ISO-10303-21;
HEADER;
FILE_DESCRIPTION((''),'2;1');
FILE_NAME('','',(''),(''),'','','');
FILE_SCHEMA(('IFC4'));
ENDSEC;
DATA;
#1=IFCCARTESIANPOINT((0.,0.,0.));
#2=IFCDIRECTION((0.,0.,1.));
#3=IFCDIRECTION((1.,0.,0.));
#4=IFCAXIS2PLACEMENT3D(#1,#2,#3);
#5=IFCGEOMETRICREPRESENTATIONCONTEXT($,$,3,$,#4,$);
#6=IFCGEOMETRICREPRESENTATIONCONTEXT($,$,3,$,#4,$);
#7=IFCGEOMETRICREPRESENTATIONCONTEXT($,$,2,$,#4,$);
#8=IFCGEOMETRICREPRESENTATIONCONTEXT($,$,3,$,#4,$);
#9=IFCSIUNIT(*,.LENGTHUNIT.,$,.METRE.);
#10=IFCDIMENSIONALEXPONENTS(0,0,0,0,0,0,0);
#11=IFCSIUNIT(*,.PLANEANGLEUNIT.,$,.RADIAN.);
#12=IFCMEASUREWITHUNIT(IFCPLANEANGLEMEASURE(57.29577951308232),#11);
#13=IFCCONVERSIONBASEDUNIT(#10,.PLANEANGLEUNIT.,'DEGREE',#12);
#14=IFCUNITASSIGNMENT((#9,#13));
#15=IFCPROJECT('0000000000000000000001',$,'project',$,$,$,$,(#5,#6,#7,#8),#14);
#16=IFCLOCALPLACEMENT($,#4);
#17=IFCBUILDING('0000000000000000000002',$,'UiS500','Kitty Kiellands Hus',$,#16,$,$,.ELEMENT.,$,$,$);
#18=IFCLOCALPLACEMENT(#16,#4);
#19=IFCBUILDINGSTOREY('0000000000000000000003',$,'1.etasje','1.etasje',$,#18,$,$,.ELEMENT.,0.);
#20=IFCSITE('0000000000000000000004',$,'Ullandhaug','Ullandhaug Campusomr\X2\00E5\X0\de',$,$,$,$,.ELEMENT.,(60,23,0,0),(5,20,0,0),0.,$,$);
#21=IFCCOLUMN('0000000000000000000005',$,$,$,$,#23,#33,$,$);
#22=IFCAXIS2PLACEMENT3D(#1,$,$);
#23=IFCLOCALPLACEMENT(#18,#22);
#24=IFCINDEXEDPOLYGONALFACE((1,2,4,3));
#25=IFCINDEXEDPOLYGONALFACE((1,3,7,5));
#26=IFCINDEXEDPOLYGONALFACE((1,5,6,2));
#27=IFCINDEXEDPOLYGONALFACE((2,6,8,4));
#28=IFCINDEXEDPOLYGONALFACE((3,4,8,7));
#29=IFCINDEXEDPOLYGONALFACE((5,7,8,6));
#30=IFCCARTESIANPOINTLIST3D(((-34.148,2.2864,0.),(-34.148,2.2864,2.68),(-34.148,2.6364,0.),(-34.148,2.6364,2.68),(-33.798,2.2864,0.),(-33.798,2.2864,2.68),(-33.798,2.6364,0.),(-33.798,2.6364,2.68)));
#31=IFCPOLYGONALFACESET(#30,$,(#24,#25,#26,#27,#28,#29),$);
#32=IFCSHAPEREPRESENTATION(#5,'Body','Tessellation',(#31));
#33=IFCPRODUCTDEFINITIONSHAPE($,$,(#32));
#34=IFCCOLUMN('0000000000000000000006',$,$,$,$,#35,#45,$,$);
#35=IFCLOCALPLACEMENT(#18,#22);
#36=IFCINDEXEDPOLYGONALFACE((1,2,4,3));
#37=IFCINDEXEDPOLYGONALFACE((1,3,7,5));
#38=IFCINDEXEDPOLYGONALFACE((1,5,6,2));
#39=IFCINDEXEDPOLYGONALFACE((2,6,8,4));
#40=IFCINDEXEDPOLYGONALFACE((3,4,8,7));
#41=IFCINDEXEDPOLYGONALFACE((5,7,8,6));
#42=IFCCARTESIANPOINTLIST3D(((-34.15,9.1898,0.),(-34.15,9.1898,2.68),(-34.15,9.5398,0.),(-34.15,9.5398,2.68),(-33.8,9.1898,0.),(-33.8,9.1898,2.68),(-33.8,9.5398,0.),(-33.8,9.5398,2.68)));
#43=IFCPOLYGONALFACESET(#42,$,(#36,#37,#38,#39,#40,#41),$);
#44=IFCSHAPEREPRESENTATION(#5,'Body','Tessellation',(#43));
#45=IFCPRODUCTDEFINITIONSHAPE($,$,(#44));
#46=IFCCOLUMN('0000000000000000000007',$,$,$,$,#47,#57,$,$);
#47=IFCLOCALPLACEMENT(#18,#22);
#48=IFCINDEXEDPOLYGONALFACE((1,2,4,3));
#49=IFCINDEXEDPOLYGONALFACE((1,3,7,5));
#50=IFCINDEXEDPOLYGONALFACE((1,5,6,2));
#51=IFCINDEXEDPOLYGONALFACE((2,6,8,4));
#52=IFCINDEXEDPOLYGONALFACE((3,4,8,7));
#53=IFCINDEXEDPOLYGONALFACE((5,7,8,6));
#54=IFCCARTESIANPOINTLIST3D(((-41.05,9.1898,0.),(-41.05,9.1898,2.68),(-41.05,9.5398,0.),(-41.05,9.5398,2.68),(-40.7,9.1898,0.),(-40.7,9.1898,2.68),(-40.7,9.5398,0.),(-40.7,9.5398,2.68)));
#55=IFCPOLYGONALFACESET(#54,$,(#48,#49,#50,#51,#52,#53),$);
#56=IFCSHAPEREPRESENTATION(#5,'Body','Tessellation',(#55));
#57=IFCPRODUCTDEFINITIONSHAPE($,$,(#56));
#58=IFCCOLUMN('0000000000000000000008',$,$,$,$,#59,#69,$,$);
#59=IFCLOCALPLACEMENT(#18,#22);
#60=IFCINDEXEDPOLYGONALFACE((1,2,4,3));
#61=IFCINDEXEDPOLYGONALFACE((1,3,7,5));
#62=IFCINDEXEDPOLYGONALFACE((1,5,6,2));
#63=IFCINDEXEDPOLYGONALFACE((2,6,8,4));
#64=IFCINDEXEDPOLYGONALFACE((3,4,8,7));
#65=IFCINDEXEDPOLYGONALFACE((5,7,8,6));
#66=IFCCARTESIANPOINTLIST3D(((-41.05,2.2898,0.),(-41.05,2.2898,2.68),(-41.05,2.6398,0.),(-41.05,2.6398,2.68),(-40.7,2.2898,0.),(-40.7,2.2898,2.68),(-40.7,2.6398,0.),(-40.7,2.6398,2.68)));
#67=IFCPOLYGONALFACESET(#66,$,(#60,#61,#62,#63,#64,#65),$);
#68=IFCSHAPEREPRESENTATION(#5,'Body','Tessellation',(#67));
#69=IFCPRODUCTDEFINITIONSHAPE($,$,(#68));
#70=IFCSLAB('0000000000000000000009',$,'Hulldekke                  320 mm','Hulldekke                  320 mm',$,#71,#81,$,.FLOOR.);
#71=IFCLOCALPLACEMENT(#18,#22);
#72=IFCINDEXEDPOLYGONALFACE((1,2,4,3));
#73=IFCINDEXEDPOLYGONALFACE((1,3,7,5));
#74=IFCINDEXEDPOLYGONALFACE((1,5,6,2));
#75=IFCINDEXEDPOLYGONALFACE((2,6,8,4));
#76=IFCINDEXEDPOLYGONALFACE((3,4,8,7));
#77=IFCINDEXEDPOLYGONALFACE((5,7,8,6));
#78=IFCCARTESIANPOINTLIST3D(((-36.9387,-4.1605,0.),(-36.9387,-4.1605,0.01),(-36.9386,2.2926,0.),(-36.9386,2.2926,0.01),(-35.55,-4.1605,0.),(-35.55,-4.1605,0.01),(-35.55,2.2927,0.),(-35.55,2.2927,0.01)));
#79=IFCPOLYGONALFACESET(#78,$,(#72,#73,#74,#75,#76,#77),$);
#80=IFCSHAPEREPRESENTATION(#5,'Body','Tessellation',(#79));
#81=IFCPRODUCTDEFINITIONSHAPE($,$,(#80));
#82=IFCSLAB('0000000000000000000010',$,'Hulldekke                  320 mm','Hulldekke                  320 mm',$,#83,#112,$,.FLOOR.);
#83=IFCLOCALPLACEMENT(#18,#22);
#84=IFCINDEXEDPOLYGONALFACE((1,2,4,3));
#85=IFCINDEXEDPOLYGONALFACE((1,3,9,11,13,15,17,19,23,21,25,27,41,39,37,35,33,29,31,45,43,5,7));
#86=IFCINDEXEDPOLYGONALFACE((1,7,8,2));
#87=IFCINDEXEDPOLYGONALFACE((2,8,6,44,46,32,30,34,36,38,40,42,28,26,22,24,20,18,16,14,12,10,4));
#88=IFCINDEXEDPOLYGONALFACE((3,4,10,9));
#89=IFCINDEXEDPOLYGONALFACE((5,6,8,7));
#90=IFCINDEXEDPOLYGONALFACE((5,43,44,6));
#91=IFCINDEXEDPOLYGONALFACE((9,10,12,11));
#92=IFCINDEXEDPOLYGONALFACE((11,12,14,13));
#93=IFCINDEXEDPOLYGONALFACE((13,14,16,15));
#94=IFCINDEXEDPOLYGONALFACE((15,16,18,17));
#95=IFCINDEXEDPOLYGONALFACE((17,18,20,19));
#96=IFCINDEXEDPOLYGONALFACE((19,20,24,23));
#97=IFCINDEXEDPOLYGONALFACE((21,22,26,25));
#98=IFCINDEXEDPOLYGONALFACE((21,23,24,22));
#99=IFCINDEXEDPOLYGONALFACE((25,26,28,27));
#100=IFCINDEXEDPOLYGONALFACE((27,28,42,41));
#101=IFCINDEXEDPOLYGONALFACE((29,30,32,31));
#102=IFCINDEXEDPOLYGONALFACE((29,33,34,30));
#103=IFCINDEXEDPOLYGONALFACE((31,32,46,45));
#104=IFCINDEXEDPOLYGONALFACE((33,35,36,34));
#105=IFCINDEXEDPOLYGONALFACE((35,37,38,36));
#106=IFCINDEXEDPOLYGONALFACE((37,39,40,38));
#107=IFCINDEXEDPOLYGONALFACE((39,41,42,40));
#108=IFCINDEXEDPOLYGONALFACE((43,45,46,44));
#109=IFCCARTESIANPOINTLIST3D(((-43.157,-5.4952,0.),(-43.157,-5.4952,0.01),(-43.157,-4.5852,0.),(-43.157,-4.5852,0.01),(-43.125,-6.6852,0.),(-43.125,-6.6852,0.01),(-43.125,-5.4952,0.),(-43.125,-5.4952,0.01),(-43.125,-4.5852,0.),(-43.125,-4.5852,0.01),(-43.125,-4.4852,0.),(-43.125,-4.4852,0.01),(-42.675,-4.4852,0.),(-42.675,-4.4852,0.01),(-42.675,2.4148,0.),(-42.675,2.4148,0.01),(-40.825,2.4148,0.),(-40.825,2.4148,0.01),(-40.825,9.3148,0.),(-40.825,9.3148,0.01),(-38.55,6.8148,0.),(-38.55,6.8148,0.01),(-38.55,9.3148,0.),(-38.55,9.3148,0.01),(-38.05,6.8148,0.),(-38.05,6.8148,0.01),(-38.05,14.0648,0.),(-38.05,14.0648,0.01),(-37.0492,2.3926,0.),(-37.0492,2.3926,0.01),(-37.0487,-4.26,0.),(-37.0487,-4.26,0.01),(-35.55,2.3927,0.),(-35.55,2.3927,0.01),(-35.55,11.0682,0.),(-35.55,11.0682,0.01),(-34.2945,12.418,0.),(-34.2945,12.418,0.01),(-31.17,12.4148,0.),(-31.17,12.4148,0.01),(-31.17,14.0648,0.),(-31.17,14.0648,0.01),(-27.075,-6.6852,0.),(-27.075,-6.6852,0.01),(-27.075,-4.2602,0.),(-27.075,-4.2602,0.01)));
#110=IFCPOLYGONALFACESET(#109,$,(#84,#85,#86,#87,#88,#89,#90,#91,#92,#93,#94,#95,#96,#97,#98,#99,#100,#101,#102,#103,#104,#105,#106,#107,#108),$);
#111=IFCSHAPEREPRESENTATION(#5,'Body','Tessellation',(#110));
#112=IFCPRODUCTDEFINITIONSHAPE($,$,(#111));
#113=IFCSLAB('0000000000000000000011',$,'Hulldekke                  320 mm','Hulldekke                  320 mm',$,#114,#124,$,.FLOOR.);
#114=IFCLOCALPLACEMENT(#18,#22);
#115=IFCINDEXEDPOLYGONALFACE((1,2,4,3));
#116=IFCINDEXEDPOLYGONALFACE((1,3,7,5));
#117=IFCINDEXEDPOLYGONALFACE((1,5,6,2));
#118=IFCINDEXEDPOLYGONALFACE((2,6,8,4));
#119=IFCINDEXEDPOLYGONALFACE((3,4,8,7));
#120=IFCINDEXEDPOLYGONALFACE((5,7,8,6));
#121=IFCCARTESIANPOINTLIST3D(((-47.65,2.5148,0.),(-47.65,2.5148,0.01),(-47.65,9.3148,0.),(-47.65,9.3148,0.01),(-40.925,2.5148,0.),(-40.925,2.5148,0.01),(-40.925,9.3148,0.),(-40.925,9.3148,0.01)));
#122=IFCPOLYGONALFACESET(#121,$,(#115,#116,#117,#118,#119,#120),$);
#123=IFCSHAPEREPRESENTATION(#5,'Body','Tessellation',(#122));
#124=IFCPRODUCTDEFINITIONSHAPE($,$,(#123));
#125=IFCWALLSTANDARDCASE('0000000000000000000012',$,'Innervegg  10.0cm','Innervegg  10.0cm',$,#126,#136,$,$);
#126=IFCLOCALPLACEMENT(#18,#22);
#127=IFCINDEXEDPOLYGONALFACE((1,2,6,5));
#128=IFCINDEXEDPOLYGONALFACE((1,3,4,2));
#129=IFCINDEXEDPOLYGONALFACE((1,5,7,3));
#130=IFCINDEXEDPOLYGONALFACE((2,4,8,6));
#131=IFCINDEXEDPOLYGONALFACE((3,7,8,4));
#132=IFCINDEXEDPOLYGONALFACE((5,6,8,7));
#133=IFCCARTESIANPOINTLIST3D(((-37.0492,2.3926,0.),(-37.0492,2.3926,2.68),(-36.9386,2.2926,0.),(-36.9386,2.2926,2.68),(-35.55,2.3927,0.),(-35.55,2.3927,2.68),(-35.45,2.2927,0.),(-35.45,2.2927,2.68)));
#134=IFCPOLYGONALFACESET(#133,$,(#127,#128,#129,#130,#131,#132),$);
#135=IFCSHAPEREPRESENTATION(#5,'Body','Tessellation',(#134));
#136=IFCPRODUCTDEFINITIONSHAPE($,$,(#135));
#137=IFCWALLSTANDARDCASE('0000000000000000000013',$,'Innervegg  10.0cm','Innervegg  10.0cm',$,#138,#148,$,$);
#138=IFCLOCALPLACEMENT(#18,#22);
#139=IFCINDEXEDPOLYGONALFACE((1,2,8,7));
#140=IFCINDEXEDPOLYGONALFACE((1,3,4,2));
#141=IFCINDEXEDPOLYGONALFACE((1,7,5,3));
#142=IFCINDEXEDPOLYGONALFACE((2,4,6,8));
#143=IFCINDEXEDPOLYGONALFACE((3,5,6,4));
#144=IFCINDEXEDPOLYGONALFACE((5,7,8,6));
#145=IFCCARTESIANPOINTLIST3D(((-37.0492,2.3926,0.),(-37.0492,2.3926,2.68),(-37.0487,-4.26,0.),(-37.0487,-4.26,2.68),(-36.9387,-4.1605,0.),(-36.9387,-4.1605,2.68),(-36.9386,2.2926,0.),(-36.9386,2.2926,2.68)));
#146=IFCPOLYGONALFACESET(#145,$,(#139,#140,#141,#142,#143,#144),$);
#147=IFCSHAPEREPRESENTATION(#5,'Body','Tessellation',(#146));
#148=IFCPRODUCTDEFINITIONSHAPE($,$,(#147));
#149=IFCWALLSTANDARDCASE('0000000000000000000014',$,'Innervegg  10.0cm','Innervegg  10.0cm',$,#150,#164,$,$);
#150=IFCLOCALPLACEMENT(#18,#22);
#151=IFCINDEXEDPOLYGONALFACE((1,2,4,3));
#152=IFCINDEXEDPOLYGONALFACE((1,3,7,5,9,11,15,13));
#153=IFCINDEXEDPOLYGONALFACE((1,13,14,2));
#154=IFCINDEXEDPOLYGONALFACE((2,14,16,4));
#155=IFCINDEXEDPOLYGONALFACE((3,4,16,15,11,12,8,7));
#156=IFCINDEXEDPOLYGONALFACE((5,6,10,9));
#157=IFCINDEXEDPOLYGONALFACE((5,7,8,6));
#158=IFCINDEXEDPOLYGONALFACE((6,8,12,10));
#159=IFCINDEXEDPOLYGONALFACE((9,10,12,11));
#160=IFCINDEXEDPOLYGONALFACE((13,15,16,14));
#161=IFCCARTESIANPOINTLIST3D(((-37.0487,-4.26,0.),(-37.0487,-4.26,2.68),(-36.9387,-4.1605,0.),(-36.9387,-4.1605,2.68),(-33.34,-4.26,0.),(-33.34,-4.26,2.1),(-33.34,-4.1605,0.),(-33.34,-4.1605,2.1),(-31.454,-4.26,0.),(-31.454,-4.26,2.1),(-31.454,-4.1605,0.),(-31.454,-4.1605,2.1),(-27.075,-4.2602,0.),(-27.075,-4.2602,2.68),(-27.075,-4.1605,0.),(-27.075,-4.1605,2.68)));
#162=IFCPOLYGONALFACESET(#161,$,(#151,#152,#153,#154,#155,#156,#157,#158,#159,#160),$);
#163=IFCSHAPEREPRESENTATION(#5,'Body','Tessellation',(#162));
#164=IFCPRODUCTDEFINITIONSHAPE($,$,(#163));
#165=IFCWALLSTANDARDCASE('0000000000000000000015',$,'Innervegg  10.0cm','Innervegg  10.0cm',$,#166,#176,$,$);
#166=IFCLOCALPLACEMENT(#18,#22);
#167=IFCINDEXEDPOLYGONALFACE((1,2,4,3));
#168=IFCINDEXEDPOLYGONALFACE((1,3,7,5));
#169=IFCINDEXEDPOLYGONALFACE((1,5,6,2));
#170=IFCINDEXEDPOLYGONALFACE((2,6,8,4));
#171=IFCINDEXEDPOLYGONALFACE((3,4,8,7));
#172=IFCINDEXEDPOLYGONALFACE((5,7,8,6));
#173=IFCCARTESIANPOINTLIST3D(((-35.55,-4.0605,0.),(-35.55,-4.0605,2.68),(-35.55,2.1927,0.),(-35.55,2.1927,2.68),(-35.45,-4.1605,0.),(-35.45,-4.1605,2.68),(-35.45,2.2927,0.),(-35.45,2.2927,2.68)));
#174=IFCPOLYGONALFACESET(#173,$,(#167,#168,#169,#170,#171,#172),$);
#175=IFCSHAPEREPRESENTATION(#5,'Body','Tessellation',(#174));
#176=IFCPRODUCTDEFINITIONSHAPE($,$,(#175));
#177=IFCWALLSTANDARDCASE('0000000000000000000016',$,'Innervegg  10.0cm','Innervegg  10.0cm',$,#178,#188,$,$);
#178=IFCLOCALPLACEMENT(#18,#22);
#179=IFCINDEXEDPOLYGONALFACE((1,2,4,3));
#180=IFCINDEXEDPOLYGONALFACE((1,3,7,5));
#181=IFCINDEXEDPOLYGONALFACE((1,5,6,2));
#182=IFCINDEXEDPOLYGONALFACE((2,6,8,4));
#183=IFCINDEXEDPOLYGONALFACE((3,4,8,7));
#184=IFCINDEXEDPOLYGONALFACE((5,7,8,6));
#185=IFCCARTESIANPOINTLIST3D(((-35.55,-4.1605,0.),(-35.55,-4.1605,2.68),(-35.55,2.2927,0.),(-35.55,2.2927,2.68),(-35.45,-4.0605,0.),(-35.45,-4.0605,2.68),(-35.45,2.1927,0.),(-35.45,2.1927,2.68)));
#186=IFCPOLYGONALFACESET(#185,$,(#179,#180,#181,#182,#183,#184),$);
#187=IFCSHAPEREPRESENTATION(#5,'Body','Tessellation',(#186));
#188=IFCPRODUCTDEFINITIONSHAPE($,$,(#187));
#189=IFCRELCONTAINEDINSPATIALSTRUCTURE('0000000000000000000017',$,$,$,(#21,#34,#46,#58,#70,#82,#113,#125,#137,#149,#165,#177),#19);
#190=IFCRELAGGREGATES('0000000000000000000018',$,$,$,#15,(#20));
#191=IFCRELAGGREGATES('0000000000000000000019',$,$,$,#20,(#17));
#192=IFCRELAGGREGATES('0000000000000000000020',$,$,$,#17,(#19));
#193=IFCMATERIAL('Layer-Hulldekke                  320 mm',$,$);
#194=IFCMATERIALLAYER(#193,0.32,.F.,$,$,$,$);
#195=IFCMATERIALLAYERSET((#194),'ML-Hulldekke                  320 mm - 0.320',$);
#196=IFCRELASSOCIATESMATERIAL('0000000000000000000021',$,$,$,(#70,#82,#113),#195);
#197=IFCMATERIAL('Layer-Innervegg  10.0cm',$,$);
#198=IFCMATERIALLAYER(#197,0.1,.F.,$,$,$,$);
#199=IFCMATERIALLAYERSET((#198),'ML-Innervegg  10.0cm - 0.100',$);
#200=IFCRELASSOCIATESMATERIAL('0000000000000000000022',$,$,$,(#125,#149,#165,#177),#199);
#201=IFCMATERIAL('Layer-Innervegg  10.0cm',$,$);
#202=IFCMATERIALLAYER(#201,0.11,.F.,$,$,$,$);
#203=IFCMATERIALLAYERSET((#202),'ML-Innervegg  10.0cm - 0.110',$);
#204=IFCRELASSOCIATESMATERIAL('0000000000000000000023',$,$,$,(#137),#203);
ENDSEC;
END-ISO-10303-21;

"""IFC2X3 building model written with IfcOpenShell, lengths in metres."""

from ifc_helpers import new_model, entity, si_unit, converted_unit, frame, origin_with_axes, origin_2d_with_axis, place, context, project, spatial, polyline, rectangle, outline, extrude, material, layer, layer_set, layer_usage, element, save


model = new_model("IFC2X3")

# Units and contexts
context_of_model_1 = context(None, 3, world=origin_with_axes())
context_of_model_2 = context(None, 3, world=origin_with_axes())
context_of_model_3 = context(None, 2, world=origin_with_axes())
context_of_model_4 = context(None, 3, world=origin_with_axes())
ifc_project = project(units=[si_unit("LENGTHUNIT", "METRE"), converted_unit("PLANEANGLEUNIT", "DEGREE", entity("IfcPlaneAngleMeasure", 57.29577951308232), si_unit("PLANEANGLEUNIT", "RADIAN"), dimensions=[0, 0, 0, 0, 0, 0, 0])], contexts=[context_of_model_1, context_of_model_2, context_of_model_3, context_of_model_4])

# Site, building, storey
site = spatial("IfcSite", under=ifc_project, Name="Ullandhaug", Description="Ullandhaug Campusområde", CompositionType="ELEMENT", RefLatitude=(60, 23, 0, 0), RefLongitude=(5, 20, 0, 0), RefElevation=0.0)
building_placement = place(None, origin_with_axes())
building = spatial("IfcBuilding", under=site, at=building_placement, Name="UiS500", Description="Kitty Kiellands Hus", CompositionType="ELEMENT")
storey_placement = place(building_placement, origin_with_axes())
storey = spatial("IfcBuildingStorey", under=building, at=storey_placement, Name="1.etasje", Description="1.etasje", CompositionType="ELEMENT", Elevation=0.0)

# Columns
for number, where, z_axis, x_axis in (
    (1, (-33.973, 2.4614, 0.0), (0.0, 0.0, 1.0), (1.0, 0.0, 0.0)),
    (2, (-33.975, 9.3648, 0.0), (0.0, 0.0, 1.0), (1.0, 0.0, 0.0)),
    (3, (-40.875, 9.3648, 0.0), (0.0, 0.0, 1.0), (1.0, 0.0, 0.0)),
    (4, (-40.875, 2.4648, 0.0), (0.0, 0.0, 1.0), (1.0, 0.0, 0.0)),
):
    element("IfcColumn", number, at=place(storey_placement, frame(where, z_axis=z_axis, x_axis=x_axis)), inside=storey, context=context_of_model_1, shape_type="SweptSolid", body=[
        extrude(rectangle(XDim=0.35, YDim=0.35, at=origin_2d_with_axis()), origin_with_axes(), (0.0, 0.0, 1.0), 2.68),
    ])

# Slabs
ifc_material_1 = material(Name="Layer-Hulldekke                  320 mm")
ifc_layer_1 = layer(ifc_material_1, 0.32, ventilated=False)
ifc_layer_set_1 = layer_set([ifc_layer_1], Name="ML-Hulldekke                  320 mm - 0.320")
ifc_layer_usage_1 = layer_usage(ifc_layer_set_1, "AXIS2", "POSITIVE", 0.0)
slab_1_placement = place(storey_placement, frame((-35.55, 2.2927, 0.0), z_axis=(0.0, 0.0, 1.0), x_axis=(1.0, 0.0, 0.0)))
element("IfcSlab", 5, at=slab_1_placement, inside=storey, material=ifc_layer_usage_1, Name="Hulldekke                  320 mm", Description="Hulldekke                  320 mm", PredefinedType="FLOOR", context=context_of_model_1, shape_type="SweptSolid", body=[
    extrude(outline(polyline([(0.0, 0.0), (1.3886, 0.0), (1.3891, 6.4531), (0.0005, 6.4532), (0.0, 0.0)])), frame((0.0, 0.0, 0.0), z_axis=(0.0, 0.0, 1.0), x_axis=(-1.0, -0.000075, 0.0)), (0.0, 0.0, 1.0), 0.01),
])
slab_2_placement = place(storey_placement, frame((-40.825, 9.3148, 0.0), z_axis=(0.0, 0.0, 1.0), x_axis=(1.0, 0.0, 0.0)))
element("IfcSlab", 6, at=slab_2_placement, inside=storey, material=ifc_layer_usage_1, Name="Hulldekke                  320 mm", Description="Hulldekke                  320 mm", PredefinedType="FLOOR", context=context_of_model_1, shape_type="SweptSolid", body=[
    extrude(outline(polyline([(0.0, 0.0), (6.9, 0.0), (6.9, 1.85), (13.8, 1.85), (13.8, 2.3), (13.9, 2.3), (13.9, 2.332), (14.81, 2.332), (14.81, 2.3), (16.0, 2.3), (16.0, -13.75), (13.575, -13.75), (13.5747, -3.7763), (6.9221, -3.7758), (6.922, -5.275), (-1.7534, -5.275), (-3.1032, -6.5305), (-3.1, -9.655), (-4.75, -9.655), (-4.75, -2.775), (2.5, -2.775), (2.5, -2.275), (0.0, -2.275), (0.0, 0.0)])), frame((0.0, 0.0, 0.0), z_axis=(0.0, 0.0, -1.0), x_axis=(0.0, -1.0, 0.0)), (0.0, 0.0, -1.0), 0.01),
])
slab_3_placement = place(storey_placement, frame((-40.925, 2.5148, 0.0), z_axis=(0.0, 0.0, 1.0), x_axis=(1.0, 0.0, 0.0)))
element("IfcSlab", 7, at=slab_3_placement, inside=storey, material=ifc_layer_usage_1, Name="Hulldekke                  320 mm", Description="Hulldekke                  320 mm", PredefinedType="FLOOR", context=context_of_model_1, shape_type="SweptSolid", body=[
    extrude(outline(polyline([(0.0, 0.0), (6.8, 0.0), (6.8, 6.725), (0.0, 6.725), (0.0, 0.0)])), frame((0.0, 0.0, 0.0), z_axis=(0.0, 0.0, 1.0), x_axis=(0.0, 1.0, 0.0)), (0.0, 0.0, 1.0), 0.01),
])

# Walls
ifc_material_2 = material(Name="Layer-Innervegg  10.0cm")
ifc_layer_2 = layer(ifc_material_2, 0.1, ventilated=False)
ifc_layer_set_2 = layer_set([ifc_layer_2], Name="ML-Innervegg  10.0cm - 0.100")
ifc_layer_usage_2 = layer_usage(ifc_layer_set_2, "AXIS2", "POSITIVE", 0.0)
wall_1_placement = place(storey_placement, frame((-35.55, 2.3927, 0.0), z_axis=(0.0, 0.0, 1.0), x_axis=(-1.0, -0.000075, 0.0)))
element("IfcWallStandardCase", 8, at=wall_1_placement, inside=storey, material=ifc_layer_usage_2, Name="Innervegg  10.0cm", Description="Innervegg  10.0cm", context=context_of_model_1, shape_type="SweptSolid", body=[
    extrude(outline(polyline([(0.0, 0.0), (1.4992, 0.0), (1.3886, 0.1), (-0.1, 0.1), (0.0, 0.0)])), frame((0.0, 0.0, 0.0), z_axis=(0.0, 0.0, 1.0), x_axis=(1.0, 0.0, 0.0)), (0.0, 0.0, 1.0), 2.68),
])
ifc_material_3 = material(Name="Layer-Innervegg  10.0cm")
ifc_layer_3 = layer(ifc_material_3, 0.11, ventilated=False)
ifc_layer_set_3 = layer_set([ifc_layer_3], Name="ML-Innervegg  10.0cm - 0.110")
ifc_layer_usage_3 = layer_usage(ifc_layer_set_3, "AXIS2", "POSITIVE", 0.0)
wall_2_placement = place(storey_placement, frame((-37.0492, 2.3926, 0.0), z_axis=(0.0, 0.0, 1.0), x_axis=(0.000075, -1.0, 0.0)))
element("IfcWallStandardCase", 9, at=wall_2_placement, inside=storey, material=ifc_layer_usage_3, Name="Innervegg  10.0cm", Description="Innervegg  10.0cm", context=context_of_model_1, shape_type="SweptSolid", body=[
    extrude(outline(polyline([(0.0, 0.0), (6.6526, 0.0), (6.5531, 0.11), (0.1, 0.1105), (0.0, 0.0)])), frame((0.0, 0.0, 0.0), z_axis=(0.0, 0.0, 1.0), x_axis=(1.0, 0.0, 0.0)), (0.0, 0.0, 1.0), 2.68),
])

# Wall, opening
wall_3_placement = place(storey_placement, frame((-37.0487, -4.26, 0.0), z_axis=(0.0, 0.0, 1.0), x_axis=(1.0, -0.000025, 0.0)))
wall_3 = element("IfcWallStandardCase", 10, at=wall_3_placement, inside=storey, material=ifc_layer_usage_2, Name="Innervegg  10.0cm", Description="Innervegg  10.0cm", context=context_of_model_1, shape_type="SweptSolid", body=[
    extrude(outline(polyline([(0.0, 0.0), (9.9737, 0.0), (9.9737, 0.0998), (0.11, 0.0995), (0.0, 0.0)])), frame((0.0, 0.0, 0.0), z_axis=(0.0, 0.0, 1.0), x_axis=(1.0, 0.0, 0.0)), (0.0, 0.0, 1.0), 2.68),
])
opening_placement = place(wall_3_placement, frame((3.7087, 0.0996, 0.0), z_axis=(0.0, 0.0, 1.0), x_axis=(1.0, 0.0, 0.0)))
element("IfcOpeningElement", 11, at=opening_placement, cuts=wall_3, context=context_of_model_1, shape_type="SweptSolid", body=[
    extrude(outline(polyline([(0.0, 0.0), (2.1, 0.0), (2.1, 1.886), (0.0, 1.886), (0.0, 0.0)])), frame((0.0, 0.0, 0.0), z_axis=(-0.000025, 1.0, 0.0), x_axis=(0.0, 0.0, 1.0)), (0.0, -0.000025, -1.0), 0.0995),
])

# Walls
wall_4_placement = place(storey_placement, frame((-35.55, 2.1927, 0.0), z_axis=(0.0, 0.0, 1.0), x_axis=(0.0, -1.0, 0.0)))
element("IfcWallStandardCase", 12, at=wall_4_placement, inside=storey, material=ifc_layer_usage_2, Name="Innervegg  10.0cm", Description="Innervegg  10.0cm", context=context_of_model_1, shape_type="SweptSolid", body=[
    extrude(outline(polyline([(0.0, 0.0), (6.2532, 0.0), (6.3532, 0.1), (-0.1, 0.1), (0.0, 0.0)])), frame((0.0, 0.0, 0.0), z_axis=(0.0, 0.0, 1.0), x_axis=(1.0, 0.0, 0.0)), (0.0, 0.0, 1.0), 2.68),
])
wall_5_placement = place(storey_placement, frame((-35.45, -4.0605, 0.0), z_axis=(0.0, 0.0, 1.0), x_axis=(0.0, 1.0, 0.0)))
element("IfcWallStandardCase", 13, at=wall_5_placement, inside=storey, material=ifc_layer_usage_2, Name="Innervegg  10.0cm", Description="Innervegg  10.0cm", context=context_of_model_1, shape_type="SweptSolid", body=[
    extrude(outline(polyline([(0.0, 0.0), (6.2532, 0.0), (6.3532, 0.1), (-0.1, 0.1), (0.0, 0.0)])), frame((0.0, 0.0, 0.0), z_axis=(0.0, 0.0, 1.0), x_axis=(1.0, 0.0, 0.0)), (0.0, 0.0, 1.0), 2.68),
])

save(model, "model.ifc")
